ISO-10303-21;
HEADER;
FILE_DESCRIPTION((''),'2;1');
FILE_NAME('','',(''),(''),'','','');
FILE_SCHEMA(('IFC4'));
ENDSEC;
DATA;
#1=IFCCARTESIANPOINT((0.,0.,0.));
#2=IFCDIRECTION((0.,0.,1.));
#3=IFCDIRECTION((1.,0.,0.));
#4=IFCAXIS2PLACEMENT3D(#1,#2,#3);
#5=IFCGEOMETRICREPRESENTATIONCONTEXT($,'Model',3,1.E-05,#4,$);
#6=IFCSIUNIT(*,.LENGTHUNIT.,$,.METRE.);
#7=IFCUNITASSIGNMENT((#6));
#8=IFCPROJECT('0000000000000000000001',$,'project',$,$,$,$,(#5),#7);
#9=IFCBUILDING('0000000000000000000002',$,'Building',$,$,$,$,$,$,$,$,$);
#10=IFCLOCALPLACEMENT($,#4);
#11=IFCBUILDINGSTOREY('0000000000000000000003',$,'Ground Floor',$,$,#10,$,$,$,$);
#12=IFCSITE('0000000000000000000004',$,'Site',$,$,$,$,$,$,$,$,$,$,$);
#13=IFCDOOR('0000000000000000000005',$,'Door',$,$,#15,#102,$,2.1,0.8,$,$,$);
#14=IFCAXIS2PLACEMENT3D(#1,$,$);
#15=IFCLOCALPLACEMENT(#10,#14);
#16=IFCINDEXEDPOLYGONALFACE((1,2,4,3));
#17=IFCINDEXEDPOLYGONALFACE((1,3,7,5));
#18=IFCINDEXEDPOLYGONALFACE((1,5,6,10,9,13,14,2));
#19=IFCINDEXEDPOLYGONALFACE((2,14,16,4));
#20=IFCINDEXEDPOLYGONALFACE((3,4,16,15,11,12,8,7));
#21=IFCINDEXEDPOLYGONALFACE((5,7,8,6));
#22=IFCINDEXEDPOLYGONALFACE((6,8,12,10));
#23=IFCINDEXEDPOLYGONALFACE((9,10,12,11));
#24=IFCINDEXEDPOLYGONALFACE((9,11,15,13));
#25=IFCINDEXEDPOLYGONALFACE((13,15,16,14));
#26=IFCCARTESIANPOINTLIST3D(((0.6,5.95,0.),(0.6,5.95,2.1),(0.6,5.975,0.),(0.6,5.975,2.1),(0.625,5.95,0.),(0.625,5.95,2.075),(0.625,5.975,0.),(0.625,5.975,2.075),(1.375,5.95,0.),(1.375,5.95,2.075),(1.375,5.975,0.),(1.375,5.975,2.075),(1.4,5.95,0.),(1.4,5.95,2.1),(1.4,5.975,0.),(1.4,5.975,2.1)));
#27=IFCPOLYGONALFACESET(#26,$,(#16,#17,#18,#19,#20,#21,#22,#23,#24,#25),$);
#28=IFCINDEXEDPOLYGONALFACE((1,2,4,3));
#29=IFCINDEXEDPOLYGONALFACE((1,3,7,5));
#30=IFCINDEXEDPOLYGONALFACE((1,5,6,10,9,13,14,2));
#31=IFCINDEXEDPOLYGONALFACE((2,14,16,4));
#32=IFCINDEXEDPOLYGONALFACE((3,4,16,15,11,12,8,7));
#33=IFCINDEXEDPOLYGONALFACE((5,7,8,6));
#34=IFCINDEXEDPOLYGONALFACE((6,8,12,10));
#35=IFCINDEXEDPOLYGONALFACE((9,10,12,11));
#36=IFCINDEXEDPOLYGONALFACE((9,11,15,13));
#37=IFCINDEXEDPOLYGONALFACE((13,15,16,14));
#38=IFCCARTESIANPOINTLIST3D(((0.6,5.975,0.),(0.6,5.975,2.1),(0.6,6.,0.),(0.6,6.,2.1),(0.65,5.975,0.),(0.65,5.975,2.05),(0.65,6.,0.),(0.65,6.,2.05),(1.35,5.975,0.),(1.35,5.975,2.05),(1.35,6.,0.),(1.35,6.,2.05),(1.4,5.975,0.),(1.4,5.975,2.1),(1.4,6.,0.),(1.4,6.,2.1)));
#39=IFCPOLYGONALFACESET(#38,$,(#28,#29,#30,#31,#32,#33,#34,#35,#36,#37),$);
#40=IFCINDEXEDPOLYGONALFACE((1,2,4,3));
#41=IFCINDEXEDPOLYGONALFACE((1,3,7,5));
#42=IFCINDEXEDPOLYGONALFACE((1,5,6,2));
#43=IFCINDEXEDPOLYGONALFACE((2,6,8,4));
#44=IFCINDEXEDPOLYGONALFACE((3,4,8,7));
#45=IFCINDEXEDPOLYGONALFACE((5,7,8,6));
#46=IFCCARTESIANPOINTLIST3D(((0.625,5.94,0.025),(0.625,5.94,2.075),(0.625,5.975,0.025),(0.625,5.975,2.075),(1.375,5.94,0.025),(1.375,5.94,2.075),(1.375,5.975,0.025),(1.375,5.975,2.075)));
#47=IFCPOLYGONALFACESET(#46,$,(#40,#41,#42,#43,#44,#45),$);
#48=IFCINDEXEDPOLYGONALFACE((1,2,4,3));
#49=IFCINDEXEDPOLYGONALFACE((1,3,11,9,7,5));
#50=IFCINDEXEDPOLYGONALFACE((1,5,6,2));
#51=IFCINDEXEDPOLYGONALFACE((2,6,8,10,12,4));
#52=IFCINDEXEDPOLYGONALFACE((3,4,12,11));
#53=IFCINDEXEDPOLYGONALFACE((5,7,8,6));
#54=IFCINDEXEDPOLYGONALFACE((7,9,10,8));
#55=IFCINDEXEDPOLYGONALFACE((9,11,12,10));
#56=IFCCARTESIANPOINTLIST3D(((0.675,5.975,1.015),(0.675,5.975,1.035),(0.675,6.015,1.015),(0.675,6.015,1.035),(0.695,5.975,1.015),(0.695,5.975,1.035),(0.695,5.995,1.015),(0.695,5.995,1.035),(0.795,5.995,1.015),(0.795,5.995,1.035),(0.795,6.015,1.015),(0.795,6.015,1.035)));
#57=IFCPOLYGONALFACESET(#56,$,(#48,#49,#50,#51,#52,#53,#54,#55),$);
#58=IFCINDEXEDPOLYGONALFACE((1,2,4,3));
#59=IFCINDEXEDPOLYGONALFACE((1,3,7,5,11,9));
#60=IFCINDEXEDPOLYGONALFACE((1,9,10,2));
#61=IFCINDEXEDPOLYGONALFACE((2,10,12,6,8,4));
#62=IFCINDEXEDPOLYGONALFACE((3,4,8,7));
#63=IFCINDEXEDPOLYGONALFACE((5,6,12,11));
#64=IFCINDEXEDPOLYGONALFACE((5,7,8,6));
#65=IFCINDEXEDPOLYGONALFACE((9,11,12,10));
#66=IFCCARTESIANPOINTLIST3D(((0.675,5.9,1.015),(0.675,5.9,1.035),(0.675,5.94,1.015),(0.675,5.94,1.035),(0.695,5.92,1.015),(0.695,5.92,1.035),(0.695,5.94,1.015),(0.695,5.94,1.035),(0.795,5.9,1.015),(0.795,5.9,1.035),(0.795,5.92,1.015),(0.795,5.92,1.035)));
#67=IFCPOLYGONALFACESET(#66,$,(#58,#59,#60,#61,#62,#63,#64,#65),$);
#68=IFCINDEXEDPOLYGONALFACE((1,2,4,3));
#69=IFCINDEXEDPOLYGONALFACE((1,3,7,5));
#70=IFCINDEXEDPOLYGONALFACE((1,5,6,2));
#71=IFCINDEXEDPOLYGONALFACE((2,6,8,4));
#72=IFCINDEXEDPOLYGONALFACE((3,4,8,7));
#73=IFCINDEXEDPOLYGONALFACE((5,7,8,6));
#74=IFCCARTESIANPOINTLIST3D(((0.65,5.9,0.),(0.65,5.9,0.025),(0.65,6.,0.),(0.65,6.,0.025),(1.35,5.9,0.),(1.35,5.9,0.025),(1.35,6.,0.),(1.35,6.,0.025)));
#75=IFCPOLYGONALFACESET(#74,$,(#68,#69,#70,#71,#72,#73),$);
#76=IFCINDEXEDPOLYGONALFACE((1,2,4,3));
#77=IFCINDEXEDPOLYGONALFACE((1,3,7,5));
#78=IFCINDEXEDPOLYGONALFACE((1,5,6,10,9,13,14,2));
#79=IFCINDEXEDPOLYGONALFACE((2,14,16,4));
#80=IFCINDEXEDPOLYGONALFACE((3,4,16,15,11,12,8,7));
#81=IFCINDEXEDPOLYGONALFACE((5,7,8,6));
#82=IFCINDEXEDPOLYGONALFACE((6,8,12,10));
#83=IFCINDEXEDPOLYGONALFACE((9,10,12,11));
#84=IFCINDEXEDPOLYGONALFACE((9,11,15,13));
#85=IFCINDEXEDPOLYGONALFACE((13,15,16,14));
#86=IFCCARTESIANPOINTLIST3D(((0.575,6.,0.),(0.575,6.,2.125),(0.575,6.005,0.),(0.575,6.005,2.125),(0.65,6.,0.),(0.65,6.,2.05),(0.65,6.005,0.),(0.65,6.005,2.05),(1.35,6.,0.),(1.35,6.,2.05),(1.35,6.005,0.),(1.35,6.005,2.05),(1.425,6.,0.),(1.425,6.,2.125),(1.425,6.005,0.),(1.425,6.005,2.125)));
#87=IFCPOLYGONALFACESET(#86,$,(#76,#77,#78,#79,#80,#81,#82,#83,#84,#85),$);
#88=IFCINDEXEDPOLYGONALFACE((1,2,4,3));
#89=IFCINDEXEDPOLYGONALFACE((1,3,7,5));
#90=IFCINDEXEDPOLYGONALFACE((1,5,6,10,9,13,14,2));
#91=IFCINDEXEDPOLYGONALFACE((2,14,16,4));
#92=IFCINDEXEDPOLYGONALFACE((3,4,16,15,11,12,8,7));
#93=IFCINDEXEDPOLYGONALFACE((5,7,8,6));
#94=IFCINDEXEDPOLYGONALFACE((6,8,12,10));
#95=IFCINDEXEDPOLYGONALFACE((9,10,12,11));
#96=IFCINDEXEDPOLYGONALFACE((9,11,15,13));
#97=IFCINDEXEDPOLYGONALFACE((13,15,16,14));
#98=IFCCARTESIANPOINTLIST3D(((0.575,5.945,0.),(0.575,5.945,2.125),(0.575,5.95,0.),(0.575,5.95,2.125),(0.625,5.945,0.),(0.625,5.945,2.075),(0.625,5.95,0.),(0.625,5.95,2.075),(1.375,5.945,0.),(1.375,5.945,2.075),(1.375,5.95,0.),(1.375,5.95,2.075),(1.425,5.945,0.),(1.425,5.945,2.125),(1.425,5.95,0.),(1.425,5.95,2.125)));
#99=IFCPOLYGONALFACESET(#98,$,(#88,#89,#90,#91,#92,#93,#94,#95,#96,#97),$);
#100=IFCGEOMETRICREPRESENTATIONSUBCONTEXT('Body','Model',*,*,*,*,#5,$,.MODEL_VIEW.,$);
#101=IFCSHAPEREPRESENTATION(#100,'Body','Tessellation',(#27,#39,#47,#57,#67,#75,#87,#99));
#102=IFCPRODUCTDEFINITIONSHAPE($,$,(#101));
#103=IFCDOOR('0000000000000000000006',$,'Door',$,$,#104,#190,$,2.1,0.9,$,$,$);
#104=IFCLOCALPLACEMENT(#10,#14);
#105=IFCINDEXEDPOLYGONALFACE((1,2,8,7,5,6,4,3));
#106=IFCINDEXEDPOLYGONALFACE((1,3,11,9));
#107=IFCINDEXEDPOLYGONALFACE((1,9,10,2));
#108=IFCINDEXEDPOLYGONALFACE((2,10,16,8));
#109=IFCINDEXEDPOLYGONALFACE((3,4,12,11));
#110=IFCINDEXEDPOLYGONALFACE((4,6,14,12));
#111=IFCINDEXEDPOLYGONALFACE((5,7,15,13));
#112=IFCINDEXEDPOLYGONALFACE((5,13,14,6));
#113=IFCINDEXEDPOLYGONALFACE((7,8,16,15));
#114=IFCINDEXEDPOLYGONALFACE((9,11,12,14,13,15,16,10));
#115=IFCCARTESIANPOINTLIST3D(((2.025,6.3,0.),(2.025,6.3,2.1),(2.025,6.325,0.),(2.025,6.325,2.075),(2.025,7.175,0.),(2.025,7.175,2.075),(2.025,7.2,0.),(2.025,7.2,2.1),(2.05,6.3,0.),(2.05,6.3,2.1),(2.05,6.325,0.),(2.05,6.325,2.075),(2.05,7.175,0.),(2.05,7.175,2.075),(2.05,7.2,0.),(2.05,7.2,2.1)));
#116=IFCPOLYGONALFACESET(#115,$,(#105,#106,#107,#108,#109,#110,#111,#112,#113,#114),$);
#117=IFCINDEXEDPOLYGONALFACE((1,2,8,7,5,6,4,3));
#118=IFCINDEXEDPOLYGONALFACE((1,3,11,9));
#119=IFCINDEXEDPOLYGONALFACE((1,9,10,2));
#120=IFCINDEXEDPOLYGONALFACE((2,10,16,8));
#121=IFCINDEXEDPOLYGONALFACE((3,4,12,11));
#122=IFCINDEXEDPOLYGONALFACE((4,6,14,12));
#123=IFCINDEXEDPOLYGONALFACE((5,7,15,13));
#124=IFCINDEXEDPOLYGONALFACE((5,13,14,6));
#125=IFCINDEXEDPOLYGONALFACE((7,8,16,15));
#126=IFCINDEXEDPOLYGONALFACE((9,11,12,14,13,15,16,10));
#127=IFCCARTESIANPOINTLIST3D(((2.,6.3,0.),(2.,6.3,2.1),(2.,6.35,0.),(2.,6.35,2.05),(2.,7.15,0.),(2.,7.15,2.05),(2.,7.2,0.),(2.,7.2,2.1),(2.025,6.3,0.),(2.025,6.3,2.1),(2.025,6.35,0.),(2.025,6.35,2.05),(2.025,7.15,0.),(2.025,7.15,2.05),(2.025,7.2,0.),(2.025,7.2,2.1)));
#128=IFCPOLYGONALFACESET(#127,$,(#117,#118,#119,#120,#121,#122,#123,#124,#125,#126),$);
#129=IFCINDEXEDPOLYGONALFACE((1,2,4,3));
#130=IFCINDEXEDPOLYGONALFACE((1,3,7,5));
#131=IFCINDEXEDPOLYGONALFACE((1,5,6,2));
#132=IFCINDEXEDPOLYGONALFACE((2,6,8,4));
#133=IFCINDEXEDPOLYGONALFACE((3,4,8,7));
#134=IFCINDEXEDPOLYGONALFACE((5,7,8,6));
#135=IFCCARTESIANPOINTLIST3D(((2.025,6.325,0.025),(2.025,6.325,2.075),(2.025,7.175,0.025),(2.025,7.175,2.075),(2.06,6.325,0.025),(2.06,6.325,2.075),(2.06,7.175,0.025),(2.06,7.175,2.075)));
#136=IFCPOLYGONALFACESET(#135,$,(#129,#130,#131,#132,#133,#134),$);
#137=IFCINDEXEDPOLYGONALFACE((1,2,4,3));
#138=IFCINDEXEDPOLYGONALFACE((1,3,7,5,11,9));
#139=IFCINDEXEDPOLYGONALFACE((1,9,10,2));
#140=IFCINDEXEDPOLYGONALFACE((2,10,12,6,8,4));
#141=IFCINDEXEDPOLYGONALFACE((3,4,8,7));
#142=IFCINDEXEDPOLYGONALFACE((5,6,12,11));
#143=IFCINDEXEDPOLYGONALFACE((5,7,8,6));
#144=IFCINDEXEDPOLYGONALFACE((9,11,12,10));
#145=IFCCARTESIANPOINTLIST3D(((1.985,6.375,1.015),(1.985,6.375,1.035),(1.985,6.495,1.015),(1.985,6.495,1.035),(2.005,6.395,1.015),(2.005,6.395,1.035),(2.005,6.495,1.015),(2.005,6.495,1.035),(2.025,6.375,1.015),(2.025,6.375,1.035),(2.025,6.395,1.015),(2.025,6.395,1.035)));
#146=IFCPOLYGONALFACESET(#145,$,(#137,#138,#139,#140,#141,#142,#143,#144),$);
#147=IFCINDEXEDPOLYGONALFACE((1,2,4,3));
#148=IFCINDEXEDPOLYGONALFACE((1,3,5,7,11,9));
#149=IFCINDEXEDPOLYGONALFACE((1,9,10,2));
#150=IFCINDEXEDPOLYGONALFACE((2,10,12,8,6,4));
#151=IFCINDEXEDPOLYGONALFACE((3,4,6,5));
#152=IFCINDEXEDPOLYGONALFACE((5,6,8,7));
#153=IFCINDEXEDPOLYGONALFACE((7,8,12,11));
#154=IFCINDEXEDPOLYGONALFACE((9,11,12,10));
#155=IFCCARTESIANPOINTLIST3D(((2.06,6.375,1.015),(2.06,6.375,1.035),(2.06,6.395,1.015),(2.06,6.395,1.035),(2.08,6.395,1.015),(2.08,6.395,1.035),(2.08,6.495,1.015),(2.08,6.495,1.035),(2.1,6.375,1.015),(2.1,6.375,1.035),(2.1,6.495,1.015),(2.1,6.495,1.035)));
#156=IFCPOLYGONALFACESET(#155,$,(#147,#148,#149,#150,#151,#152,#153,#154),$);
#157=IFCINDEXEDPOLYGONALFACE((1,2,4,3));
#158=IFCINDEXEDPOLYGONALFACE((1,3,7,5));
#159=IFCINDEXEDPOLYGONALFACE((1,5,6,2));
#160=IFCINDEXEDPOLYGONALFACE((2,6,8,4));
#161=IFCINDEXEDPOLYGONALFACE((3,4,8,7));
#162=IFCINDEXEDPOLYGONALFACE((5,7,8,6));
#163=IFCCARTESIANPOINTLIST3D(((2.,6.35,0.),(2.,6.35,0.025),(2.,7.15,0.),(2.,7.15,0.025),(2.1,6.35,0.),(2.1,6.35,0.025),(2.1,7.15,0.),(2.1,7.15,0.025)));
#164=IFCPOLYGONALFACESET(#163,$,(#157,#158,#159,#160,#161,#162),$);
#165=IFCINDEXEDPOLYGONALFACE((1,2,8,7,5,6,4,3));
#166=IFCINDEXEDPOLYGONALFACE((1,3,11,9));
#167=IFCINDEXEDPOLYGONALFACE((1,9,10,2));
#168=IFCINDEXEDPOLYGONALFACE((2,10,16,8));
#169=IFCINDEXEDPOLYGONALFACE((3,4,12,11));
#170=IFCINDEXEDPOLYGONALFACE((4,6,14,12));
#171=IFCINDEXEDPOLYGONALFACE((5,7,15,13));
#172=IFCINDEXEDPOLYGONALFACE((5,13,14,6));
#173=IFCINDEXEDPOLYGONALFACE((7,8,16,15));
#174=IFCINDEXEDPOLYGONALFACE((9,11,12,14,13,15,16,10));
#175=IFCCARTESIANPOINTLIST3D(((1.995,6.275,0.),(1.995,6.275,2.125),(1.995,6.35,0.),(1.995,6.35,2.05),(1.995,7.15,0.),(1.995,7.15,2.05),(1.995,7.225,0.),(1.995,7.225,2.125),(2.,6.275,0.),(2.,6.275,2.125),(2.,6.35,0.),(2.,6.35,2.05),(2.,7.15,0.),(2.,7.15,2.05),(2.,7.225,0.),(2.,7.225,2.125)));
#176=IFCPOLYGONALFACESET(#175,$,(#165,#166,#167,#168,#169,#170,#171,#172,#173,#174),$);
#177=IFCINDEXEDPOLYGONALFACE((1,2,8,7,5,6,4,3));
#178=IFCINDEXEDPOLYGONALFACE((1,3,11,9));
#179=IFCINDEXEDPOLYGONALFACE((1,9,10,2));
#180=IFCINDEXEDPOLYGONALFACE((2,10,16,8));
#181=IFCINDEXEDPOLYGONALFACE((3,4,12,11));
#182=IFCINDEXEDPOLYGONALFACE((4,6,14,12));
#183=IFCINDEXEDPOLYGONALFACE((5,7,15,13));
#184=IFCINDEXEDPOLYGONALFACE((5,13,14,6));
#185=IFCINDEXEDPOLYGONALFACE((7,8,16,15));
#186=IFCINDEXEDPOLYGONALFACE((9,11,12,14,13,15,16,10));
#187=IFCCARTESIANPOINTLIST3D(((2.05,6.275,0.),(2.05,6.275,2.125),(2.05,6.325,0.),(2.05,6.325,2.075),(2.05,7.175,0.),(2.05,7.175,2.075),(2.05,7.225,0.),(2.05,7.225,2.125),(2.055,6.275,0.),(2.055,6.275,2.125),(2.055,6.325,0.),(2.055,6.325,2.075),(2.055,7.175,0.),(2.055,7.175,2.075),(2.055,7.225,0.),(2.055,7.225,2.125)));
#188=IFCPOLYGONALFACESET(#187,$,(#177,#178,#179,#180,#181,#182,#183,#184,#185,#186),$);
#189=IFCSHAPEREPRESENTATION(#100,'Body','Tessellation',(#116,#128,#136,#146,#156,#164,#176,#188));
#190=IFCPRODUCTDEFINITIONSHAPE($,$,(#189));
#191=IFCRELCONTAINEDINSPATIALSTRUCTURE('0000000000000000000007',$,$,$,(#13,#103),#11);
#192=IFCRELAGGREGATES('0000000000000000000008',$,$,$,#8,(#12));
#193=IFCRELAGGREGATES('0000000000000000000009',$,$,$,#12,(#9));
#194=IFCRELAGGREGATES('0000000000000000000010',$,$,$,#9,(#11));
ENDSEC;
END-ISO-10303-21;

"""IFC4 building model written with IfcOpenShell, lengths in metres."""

from ifc_helpers import new_model, si_unit, frame, origin_with_axes, place, context, subcontext, project, spatial, line, indexed_curve, outline, extrude, element, save


model = new_model("IFC4")

# Units and contexts
model_context = context("Model", 3, precision=1e-05, world=origin_with_axes())
body_context = subcontext(model_context, "Body", "Model", "MODEL_VIEW")
ifc_project = project(units=[si_unit("LENGTHUNIT", "METRE")], contexts=[model_context])

# Site, building, storey
site = spatial("IfcSite", under=ifc_project, Name="Site")
building = spatial("IfcBuilding", under=site, Name="Building")
storey_placement = place(None, origin_with_axes())
storey = spatial("IfcBuildingStorey", under=building, at=storey_placement, Name="Ground Floor")

# Doors
door_1_placement = place(storey_placement, frame((1.4, 6.0, 0.0), z_axis=(0.0, 0.0, 1.0), x_axis=(-1.0, 0.0, 0.0)))
element("IfcDoor", 1, at=door_1_placement, inside=storey, Name="Door", OverallHeight=2.1, OverallWidth=0.8, context=body_context, shape_type="SweptSolid", body=[
    extrude(outline(indexed_curve([(0.0, 0.0), (0.0, 2.1), (0.8, 2.1), (0.8, 0.0), (0.775, 0.0), (0.775, 2.075), (0.025, 2.075), (0.025, 0.0)], segments=[line(1, 2, 3, 4, 5, 6, 7, 8, 1)])), frame((0.0, 0.025, 0.0), z_axis=(0.0, -1.0, 0.0), x_axis=(1.0, 0.0, 0.0)), (0.0, 0.0, -1.0), 0.025),
    extrude(outline(indexed_curve([(0.0, 0.0), (0.0, 2.1), (0.8, 2.1), (0.8, 0.0), (0.75, 0.0), (0.75, 2.05), (0.05, 2.05), (0.05, 0.0)], segments=[line(1, 2, 3, 4, 5, 6, 7, 8, 1)])), frame((0.0, 0.0, 0.0), z_axis=(0.0, -1.0, 0.0), x_axis=(1.0, 0.0, 0.0)), (0.0, 0.0, -1.0), 0.025),
    extrude(outline(indexed_curve([(0.0, 0.0), (0.75, 0.0), (0.75, 0.035), (0.0, 0.035)], segments=[line(1, 2, 3, 4, 1)])), frame((0.025, 0.025, 0.025), z_axis=(0.0, 0.0, 1.0), x_axis=(1.0, 0.0, 0.0)), (0.0, 0.0, 1.0), 2.05),
    extrude(outline(indexed_curve([(0.0, 0.0), (0.0, -0.04), (-0.12, -0.04), (-0.12, -0.02), (-0.02, -0.02), (-0.02, 0.0)], segments=[line(1, 2, 3, 4, 5, 6, 1)])), frame((0.725, 0.025, 1.015), z_axis=(0.0, 0.0, 1.0), x_axis=(1.0, 0.0, 0.0)), (0.0, 0.0, 1.0), 0.02),
    extrude(outline(indexed_curve([(0.0, 0.0), (0.0, 0.04), (-0.12, 0.04), (-0.12, 0.02), (-0.02, 0.02), (-0.02, 0.0)], segments=[line(1, 2, 3, 4, 5, 6, 1)])), frame((0.725, 0.06, 1.015), z_axis=(0.0, 0.0, 1.0), x_axis=(1.0, 0.0, 0.0)), (0.0, 0.0, 1.0), 0.02),
    extrude(outline(indexed_curve([(0.0, 0.0), (0.7, 0.0), (0.7, 0.1), (0.0, 0.1)], segments=[line(1, 2, 3, 4, 1)])), frame((0.05, 0.0, 0.0), z_axis=(0.0, 0.0, 1.0), x_axis=(1.0, 0.0, 0.0)), (0.0, 0.0, 1.0), 0.025),
    extrude(outline(indexed_curve([(0.0, 0.0), (0.0, 2.125), (0.85, 2.125), (0.85, 0.0), (0.775, 0.0), (0.775, 2.05), (0.075, 2.05), (0.075, 0.0)], segments=[line(1, 2, 3, 4, 5, 6, 7, 8, 1)])), frame((-0.025, -0.005, 0.0), z_axis=(0.0, -1.0, 0.0), x_axis=(1.0, 0.0, 0.0)), (0.0, 0.0, -1.0), 0.005),
    extrude(outline(indexed_curve([(0.0, 0.0), (0.0, 2.125), (0.85, 2.125), (0.85, 0.0), (0.8, 0.0), (0.8, 2.075), (0.05, 2.075), (0.05, 0.0)], segments=[line(1, 2, 3, 4, 5, 6, 7, 8, 1)])), frame((-0.025, 0.05, 0.0), z_axis=(0.0, -1.0, 0.0), x_axis=(1.0, 0.0, 0.0)), (0.0, 0.0, -1.0), 0.005),
])
door_2_placement = place(storey_placement, frame((2.0, 7.2, 0.0), z_axis=(0.0, 0.0, 1.0), x_axis=(0.0, -1.0, 0.0)))
element("IfcDoor", 2, at=door_2_placement, inside=storey, Name="Door", OverallHeight=2.1, OverallWidth=0.9, context=body_context, shape_type="SweptSolid", body=[
    extrude(outline(indexed_curve([(0.0, 0.0), (0.0, 2.1), (0.9, 2.1), (0.9, 0.0), (0.875, 0.0), (0.875, 2.075), (0.025, 2.075), (0.025, 0.0)], segments=[line(1, 2, 3, 4, 5, 6, 7, 8, 1)])), frame((0.0, 0.025, 0.0), z_axis=(0.0, -1.0, 0.0), x_axis=(1.0, 0.0, 0.0)), (0.0, 0.0, -1.0), 0.025),
    extrude(outline(indexed_curve([(0.0, 0.0), (0.0, 2.1), (0.9, 2.1), (0.9, 0.0), (0.85, 0.0), (0.85, 2.05), (0.05, 2.05), (0.05, 0.0)], segments=[line(1, 2, 3, 4, 5, 6, 7, 8, 1)])), frame((0.0, 0.0, 0.0), z_axis=(0.0, -1.0, 0.0), x_axis=(1.0, 0.0, 0.0)), (0.0, 0.0, -1.0), 0.025),
    extrude(outline(indexed_curve([(0.0, 0.0), (0.85, 0.0), (0.85, 0.035), (0.0, 0.035)], segments=[line(1, 2, 3, 4, 1)])), frame((0.025, 0.025, 0.025), z_axis=(0.0, 0.0, 1.0), x_axis=(1.0, 0.0, 0.0)), (0.0, 0.0, 1.0), 2.05),
    extrude(outline(indexed_curve([(0.0, 0.0), (0.0, -0.04), (-0.12, -0.04), (-0.12, -0.02), (-0.02, -0.02), (-0.02, 0.0)], segments=[line(1, 2, 3, 4, 5, 6, 1)])), frame((0.825, 0.025, 1.015), z_axis=(0.0, 0.0, 1.0), x_axis=(1.0, 0.0, 0.0)), (0.0, 0.0, 1.0), 0.02),
    extrude(outline(indexed_curve([(0.0, 0.0), (0.0, 0.04), (-0.12, 0.04), (-0.12, 0.02), (-0.02, 0.02), (-0.02, 0.0)], segments=[line(1, 2, 3, 4, 5, 6, 1)])), frame((0.825, 0.06, 1.015), z_axis=(0.0, 0.0, 1.0), x_axis=(1.0, 0.0, 0.0)), (0.0, 0.0, 1.0), 0.02),
    extrude(outline(indexed_curve([(0.0, 0.0), (0.8, 0.0), (0.8, 0.1), (0.0, 0.1)], segments=[line(1, 2, 3, 4, 1)])), frame((0.05, 0.0, 0.0), z_axis=(0.0, 0.0, 1.0), x_axis=(1.0, 0.0, 0.0)), (0.0, 0.0, 1.0), 0.025),
    extrude(outline(indexed_curve([(0.0, 0.0), (0.0, 2.125), (0.95, 2.125), (0.95, 0.0), (0.875, 0.0), (0.875, 2.05), (0.075, 2.05), (0.075, 0.0)], segments=[line(1, 2, 3, 4, 5, 6, 7, 8, 1)])), frame((-0.025, -0.005, 0.0), z_axis=(0.0, -1.0, 0.0), x_axis=(1.0, 0.0, 0.0)), (0.0, 0.0, -1.0), 0.005),
    extrude(outline(indexed_curve([(0.0, 0.0), (0.0, 2.125), (0.95, 2.125), (0.95, 0.0), (0.9, 0.0), (0.9, 2.075), (0.05, 2.075), (0.05, 0.0)], segments=[line(1, 2, 3, 4, 5, 6, 7, 8, 1)])), frame((-0.025, 0.05, 0.0), z_axis=(0.0, -1.0, 0.0), x_axis=(1.0, 0.0, 0.0)), (0.0, 0.0, -1.0), 0.005),
])

save(model, "model.ifc")
